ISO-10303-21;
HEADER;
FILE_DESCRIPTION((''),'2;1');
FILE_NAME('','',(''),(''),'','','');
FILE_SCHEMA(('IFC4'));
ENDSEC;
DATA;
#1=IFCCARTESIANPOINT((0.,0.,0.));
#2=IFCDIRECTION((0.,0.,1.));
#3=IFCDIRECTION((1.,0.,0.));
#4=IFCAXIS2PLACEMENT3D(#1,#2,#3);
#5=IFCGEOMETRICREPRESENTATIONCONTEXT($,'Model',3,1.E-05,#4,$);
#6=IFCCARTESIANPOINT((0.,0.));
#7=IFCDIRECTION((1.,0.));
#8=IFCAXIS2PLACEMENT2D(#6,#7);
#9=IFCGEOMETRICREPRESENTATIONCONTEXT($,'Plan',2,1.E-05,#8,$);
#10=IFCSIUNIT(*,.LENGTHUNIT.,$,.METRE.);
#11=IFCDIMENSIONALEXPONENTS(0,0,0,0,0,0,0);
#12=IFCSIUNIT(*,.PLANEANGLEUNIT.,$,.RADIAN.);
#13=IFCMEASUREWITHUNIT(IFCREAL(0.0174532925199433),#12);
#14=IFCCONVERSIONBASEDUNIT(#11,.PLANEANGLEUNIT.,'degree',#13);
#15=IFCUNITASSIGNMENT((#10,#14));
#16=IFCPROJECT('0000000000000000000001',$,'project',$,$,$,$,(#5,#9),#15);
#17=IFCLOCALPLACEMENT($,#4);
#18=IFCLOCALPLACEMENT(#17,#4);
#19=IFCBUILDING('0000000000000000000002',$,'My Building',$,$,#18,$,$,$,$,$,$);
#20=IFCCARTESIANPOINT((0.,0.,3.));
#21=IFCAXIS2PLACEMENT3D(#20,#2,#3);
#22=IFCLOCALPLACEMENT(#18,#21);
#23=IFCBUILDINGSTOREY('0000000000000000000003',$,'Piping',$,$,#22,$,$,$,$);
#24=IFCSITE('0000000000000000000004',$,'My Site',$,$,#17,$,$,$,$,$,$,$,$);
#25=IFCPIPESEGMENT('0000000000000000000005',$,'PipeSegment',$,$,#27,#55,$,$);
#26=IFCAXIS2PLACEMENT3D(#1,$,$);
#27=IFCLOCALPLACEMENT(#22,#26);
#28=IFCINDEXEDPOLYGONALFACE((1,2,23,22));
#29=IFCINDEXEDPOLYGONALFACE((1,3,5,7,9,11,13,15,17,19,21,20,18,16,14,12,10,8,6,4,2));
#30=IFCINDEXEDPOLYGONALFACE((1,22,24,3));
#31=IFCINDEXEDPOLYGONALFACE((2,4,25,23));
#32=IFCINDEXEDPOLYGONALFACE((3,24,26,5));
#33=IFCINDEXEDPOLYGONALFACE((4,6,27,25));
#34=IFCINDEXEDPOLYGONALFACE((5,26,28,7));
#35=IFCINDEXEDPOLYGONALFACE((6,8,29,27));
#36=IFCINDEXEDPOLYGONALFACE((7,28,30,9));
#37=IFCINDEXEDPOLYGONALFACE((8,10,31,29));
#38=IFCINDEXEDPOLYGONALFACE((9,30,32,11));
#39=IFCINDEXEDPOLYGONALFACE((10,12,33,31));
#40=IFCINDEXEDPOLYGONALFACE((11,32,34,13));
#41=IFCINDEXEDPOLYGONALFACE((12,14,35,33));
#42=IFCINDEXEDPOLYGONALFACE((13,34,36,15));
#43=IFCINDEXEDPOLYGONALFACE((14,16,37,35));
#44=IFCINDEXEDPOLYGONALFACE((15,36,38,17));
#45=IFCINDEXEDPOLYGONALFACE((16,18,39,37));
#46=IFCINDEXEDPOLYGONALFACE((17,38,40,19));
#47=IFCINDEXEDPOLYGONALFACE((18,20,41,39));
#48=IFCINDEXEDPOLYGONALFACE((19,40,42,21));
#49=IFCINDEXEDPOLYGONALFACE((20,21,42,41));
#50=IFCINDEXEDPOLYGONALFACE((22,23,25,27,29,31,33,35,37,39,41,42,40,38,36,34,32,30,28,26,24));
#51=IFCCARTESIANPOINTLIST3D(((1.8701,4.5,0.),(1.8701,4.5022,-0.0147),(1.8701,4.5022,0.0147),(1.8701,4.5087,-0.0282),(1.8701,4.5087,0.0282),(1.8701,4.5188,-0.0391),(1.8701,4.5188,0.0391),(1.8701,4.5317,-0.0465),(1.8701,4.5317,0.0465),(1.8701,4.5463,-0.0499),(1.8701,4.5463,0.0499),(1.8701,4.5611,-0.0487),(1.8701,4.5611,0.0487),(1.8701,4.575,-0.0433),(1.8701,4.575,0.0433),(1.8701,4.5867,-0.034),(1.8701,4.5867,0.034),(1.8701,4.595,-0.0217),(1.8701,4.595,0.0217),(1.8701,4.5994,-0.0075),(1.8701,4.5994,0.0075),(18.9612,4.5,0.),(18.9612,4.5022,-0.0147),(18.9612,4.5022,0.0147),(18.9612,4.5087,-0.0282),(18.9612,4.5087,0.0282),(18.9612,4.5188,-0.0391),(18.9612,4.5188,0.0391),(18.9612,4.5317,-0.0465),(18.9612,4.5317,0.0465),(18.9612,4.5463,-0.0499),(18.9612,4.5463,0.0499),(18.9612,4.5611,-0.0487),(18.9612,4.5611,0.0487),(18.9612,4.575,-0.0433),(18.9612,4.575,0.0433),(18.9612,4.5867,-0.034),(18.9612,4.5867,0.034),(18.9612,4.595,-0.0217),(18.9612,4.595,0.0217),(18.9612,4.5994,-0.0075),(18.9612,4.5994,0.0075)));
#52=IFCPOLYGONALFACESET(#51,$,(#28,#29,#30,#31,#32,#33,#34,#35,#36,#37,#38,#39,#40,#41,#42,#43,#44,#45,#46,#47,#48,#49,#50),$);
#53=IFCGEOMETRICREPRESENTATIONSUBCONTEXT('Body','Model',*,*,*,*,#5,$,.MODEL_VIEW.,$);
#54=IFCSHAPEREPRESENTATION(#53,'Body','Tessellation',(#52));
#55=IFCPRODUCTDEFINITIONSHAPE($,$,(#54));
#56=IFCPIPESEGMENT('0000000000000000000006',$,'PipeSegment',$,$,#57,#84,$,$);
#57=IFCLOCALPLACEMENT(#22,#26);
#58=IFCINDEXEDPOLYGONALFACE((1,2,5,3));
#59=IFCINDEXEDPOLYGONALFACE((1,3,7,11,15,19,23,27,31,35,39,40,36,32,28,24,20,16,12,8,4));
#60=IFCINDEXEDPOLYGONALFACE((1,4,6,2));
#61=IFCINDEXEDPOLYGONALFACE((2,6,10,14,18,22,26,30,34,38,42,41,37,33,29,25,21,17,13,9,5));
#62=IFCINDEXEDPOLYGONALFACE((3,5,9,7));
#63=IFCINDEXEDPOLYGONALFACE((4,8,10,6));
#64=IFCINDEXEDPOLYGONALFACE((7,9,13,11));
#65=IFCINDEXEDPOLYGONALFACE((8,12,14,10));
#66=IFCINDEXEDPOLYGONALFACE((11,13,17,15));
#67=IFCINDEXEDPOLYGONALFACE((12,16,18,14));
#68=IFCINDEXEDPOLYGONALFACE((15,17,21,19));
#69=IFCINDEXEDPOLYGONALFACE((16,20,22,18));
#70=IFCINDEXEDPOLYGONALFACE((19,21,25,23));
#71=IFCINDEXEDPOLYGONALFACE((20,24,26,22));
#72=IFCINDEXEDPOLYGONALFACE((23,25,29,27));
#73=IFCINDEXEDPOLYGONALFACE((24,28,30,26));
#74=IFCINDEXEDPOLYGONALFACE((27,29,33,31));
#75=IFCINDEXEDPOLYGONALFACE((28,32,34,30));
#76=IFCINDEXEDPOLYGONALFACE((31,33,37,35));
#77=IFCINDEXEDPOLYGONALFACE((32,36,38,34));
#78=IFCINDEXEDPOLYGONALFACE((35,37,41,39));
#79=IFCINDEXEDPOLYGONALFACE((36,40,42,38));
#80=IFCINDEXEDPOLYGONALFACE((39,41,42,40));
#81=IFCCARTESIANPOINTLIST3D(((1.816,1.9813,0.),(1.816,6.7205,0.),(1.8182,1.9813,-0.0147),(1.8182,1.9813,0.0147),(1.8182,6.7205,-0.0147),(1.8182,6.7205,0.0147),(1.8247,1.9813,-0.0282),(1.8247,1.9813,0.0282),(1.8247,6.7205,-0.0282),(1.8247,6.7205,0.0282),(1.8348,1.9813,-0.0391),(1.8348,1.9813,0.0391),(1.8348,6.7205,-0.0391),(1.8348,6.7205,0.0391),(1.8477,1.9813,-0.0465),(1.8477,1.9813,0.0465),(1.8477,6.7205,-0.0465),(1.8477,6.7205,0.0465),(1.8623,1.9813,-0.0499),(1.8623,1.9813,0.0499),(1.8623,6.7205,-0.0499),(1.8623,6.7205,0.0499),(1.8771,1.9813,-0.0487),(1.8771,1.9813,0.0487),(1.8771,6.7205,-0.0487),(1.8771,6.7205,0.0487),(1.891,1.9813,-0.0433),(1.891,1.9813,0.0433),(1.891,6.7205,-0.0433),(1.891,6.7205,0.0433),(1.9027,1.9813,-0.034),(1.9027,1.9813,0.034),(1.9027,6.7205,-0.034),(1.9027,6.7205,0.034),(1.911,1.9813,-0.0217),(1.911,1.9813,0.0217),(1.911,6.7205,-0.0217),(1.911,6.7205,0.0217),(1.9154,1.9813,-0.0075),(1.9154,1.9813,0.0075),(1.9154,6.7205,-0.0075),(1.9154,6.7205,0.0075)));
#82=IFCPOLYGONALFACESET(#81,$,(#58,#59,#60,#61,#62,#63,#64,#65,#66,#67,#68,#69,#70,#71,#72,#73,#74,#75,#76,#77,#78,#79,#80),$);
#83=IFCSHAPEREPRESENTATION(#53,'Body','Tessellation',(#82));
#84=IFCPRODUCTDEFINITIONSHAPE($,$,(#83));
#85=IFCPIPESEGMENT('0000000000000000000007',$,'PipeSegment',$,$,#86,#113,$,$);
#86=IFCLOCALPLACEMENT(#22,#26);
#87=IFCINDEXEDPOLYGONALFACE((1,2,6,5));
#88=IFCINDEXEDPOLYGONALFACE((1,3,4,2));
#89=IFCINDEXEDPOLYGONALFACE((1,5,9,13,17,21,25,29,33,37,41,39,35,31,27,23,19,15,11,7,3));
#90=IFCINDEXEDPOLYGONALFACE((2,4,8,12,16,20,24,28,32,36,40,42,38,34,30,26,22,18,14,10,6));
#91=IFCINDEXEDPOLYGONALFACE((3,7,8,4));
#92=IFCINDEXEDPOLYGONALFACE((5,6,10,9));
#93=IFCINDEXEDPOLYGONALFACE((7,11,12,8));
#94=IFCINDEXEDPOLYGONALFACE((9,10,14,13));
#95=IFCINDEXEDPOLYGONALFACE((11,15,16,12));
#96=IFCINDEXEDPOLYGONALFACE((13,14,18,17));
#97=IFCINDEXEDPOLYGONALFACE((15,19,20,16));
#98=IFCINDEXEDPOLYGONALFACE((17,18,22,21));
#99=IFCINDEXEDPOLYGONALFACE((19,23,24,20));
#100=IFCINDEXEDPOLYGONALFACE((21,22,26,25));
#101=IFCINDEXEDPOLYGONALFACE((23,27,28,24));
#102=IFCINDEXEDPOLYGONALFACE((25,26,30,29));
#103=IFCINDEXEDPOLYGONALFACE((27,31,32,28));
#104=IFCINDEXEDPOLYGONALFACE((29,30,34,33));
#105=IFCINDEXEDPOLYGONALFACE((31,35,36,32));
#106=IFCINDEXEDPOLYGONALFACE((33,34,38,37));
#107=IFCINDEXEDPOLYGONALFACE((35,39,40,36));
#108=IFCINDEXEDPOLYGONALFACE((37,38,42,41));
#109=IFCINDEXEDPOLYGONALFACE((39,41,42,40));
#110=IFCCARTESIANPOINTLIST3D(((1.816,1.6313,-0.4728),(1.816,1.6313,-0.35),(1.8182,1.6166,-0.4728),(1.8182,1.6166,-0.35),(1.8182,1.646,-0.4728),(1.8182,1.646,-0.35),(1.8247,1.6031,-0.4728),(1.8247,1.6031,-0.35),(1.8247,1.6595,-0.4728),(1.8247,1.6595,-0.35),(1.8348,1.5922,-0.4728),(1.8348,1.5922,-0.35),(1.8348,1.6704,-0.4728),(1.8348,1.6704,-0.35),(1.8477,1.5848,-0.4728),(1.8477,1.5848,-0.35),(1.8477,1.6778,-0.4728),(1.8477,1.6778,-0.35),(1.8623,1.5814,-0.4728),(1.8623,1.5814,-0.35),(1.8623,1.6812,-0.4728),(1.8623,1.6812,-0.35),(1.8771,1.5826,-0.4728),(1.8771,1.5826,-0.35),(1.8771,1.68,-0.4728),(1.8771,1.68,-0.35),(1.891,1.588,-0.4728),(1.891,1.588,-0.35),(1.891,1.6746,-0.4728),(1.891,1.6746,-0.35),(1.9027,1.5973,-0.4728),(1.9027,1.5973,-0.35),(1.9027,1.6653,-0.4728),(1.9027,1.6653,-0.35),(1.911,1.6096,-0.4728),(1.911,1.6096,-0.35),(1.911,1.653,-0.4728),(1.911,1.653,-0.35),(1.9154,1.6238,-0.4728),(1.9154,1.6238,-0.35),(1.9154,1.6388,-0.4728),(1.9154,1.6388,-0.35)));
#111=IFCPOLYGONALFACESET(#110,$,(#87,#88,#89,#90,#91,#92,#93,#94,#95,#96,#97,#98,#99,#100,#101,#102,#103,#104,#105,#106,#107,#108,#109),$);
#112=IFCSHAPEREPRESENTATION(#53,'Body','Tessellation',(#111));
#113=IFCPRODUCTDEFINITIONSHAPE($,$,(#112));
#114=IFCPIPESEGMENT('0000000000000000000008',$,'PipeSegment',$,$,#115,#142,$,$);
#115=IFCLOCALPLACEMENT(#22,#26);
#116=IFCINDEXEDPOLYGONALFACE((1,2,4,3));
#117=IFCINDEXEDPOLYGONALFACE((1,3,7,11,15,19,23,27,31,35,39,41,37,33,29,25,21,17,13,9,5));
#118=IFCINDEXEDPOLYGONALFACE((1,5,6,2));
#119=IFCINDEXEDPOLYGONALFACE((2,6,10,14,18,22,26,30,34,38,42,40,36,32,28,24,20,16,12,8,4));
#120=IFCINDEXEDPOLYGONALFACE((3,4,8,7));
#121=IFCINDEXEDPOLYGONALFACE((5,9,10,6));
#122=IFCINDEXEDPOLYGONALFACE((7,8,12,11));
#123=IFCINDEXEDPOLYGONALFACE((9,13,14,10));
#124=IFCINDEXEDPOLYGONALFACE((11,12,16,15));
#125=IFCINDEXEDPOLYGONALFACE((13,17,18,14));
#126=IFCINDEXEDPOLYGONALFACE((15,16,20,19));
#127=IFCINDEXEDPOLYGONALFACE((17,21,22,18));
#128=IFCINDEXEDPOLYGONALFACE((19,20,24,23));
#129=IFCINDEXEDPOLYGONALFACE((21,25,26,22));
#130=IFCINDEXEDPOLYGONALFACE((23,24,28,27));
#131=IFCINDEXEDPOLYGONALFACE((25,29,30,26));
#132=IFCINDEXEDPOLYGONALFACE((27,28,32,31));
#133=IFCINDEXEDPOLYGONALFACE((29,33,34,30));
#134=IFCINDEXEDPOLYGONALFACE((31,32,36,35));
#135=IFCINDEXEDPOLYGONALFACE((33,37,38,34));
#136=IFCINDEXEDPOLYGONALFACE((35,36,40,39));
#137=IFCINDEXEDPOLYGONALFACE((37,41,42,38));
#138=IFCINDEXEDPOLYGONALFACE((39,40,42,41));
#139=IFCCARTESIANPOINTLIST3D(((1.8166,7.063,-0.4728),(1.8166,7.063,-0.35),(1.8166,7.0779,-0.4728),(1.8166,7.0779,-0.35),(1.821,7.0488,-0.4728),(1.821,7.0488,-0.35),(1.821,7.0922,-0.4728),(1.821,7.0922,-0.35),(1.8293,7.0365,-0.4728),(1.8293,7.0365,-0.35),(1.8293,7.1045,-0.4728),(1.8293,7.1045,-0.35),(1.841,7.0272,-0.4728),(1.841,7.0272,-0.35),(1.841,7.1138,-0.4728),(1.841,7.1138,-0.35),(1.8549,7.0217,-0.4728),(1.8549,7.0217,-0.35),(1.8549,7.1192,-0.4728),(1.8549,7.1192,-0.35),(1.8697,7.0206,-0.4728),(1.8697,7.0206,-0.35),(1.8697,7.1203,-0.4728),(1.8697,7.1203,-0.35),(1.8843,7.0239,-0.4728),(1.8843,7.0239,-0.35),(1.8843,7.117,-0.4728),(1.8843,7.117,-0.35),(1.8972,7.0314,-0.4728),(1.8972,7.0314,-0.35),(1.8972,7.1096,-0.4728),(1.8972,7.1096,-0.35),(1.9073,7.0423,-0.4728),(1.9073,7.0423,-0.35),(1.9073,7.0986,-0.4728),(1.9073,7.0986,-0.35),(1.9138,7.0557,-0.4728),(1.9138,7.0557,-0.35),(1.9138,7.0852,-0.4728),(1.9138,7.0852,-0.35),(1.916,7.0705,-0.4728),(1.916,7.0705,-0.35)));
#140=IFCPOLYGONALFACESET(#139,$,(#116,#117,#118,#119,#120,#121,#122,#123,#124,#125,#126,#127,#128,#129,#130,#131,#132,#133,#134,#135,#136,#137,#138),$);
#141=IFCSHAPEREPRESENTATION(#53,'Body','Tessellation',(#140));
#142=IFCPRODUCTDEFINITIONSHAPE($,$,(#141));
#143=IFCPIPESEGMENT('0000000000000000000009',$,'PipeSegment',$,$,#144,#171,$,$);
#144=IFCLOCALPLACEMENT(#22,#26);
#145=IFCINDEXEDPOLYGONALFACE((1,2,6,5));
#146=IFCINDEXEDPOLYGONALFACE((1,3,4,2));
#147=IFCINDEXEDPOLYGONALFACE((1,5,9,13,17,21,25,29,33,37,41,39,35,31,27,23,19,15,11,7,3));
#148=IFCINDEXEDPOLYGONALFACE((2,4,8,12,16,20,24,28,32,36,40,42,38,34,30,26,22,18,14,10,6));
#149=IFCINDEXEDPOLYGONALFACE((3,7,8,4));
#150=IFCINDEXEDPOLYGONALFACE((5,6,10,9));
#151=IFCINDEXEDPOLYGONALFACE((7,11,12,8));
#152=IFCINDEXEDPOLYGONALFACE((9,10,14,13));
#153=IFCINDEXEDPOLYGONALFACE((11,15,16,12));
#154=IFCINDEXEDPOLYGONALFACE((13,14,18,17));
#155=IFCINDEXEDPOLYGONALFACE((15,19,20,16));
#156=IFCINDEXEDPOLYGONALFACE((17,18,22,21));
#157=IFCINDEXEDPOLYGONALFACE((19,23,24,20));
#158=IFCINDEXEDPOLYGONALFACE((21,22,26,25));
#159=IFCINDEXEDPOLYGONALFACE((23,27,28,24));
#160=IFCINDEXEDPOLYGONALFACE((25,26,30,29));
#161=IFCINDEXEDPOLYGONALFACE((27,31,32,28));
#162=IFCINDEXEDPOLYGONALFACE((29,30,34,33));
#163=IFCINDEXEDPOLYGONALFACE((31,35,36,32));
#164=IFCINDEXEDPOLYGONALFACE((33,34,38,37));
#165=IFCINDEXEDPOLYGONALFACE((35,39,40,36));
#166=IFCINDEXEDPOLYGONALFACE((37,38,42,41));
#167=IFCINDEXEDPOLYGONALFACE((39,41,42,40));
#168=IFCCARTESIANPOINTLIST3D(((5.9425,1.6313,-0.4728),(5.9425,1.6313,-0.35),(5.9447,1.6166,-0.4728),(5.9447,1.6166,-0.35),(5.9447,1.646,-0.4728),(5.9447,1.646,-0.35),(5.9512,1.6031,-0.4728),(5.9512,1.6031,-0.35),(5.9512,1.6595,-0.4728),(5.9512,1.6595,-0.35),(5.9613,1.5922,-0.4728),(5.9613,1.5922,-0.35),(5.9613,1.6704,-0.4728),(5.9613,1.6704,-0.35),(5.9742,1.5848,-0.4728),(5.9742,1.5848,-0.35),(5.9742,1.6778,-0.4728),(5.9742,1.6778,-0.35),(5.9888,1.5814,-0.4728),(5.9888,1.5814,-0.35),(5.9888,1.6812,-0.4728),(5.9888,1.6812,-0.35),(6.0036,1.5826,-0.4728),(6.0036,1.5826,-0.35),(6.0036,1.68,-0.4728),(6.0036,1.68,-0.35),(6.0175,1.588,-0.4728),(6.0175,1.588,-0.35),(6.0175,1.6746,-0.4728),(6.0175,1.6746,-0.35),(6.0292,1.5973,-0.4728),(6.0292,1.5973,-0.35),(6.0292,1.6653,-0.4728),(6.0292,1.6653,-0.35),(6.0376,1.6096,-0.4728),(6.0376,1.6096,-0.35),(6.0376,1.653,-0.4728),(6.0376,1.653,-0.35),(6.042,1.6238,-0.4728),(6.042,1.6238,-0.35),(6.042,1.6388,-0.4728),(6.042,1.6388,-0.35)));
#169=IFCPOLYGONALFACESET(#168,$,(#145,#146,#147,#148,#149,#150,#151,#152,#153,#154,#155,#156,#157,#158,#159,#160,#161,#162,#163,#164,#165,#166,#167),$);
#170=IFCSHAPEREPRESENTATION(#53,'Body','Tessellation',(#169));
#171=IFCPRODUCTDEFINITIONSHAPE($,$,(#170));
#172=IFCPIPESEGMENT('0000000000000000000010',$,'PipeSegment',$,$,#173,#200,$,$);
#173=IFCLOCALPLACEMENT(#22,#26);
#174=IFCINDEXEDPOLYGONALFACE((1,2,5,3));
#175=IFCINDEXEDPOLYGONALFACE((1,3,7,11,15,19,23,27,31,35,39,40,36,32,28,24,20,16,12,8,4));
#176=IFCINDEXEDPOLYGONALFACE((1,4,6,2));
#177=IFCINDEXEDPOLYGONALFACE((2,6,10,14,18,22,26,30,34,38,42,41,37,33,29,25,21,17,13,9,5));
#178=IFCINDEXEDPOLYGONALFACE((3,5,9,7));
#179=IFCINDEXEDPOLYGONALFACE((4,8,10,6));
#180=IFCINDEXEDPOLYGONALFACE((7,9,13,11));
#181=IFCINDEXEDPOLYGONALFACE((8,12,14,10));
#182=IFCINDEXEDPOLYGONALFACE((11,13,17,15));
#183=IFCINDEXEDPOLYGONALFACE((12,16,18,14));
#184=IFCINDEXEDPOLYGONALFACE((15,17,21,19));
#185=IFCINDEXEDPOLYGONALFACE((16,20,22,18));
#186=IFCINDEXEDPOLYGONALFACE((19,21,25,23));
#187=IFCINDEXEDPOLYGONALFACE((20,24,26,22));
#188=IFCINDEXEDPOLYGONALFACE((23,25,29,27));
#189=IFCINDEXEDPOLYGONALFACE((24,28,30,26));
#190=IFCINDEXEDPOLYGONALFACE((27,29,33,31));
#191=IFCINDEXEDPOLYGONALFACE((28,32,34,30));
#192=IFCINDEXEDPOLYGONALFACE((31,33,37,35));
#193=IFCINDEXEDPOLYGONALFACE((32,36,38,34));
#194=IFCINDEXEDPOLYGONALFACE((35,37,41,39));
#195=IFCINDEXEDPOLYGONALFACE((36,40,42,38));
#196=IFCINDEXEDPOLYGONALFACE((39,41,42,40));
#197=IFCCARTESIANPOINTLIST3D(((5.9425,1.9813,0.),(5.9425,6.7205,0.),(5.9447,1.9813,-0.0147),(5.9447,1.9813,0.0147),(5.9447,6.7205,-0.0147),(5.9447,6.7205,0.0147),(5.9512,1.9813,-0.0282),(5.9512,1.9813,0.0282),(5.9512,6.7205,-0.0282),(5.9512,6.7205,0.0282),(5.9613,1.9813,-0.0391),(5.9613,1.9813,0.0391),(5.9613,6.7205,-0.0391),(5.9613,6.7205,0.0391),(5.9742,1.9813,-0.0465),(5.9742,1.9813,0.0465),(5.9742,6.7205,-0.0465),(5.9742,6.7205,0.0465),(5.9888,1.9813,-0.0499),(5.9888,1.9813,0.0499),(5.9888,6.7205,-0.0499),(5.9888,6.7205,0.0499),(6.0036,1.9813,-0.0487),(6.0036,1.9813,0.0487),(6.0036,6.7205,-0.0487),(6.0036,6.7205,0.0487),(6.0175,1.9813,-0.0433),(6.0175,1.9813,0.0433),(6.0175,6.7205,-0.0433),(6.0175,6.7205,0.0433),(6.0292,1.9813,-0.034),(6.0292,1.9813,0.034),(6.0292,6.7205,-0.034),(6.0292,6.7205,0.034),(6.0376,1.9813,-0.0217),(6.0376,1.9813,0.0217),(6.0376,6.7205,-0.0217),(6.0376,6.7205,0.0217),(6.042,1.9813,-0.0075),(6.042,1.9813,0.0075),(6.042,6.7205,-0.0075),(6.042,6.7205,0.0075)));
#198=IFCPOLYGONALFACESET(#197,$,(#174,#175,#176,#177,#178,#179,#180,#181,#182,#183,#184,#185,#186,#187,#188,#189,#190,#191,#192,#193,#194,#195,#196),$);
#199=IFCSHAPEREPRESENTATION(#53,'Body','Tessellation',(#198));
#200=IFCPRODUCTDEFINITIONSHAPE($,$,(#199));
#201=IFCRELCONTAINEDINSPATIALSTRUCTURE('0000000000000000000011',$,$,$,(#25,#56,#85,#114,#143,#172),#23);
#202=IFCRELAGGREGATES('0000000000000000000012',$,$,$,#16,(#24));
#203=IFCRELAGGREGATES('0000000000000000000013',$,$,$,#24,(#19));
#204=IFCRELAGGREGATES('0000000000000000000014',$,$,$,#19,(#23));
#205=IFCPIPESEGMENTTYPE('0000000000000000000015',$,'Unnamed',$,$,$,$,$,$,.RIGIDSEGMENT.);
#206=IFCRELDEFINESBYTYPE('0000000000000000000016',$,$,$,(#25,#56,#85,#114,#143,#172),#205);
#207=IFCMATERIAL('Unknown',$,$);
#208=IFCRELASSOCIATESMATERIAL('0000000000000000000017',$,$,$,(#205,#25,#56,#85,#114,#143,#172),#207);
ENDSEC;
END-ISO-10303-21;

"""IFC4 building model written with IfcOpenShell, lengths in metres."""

from ifc_helpers import new_model, entity, si_unit, converted_unit, frame, origin_with_axes, origin_2d_with_axis, place, context, subcontext, project, spatial, circle, extrude, material, material_profile, profile_set, profile_usage, type_object, element, save


model = new_model("IFC4")

# Units and contexts
model_context = context("Model", 3, precision=1e-05, world=origin_with_axes())
plan_context = context("Plan", 2, precision=1e-05, world=origin_2d_with_axis())
body_context = subcontext(model_context, "Body", "Model", "MODEL_VIEW")
ifc_project = project(units=[si_unit("LENGTHUNIT", "METRE"), converted_unit("PLANEANGLEUNIT", "degree", entity("IfcReal", 0.0174532925199433), si_unit("PLANEANGLEUNIT", "RADIAN"), dimensions=[0, 0, 0, 0, 0, 0, 0])], contexts=[model_context, plan_context])

# Site, building, storey
site_placement = place(None, origin_with_axes())
site = spatial("IfcSite", under=ifc_project, at=site_placement, Name="My Site")
building_placement = place(site_placement, origin_with_axes())
building = spatial("IfcBuilding", under=site, at=building_placement, Name="My Building")
storey_placement = place(building_placement, frame((0.0, 0.0, 3.0), z_axis=(0.0, 0.0, 1.0), x_axis=(1.0, 0.0, 0.0)))
storey = spatial("IfcBuildingStorey", under=building, at=storey_placement, Name="Piping")

# Pipe segments
ifc_material = material(Name="Unknown")
ifc_material_profile = material_profile(ifc_material, circle(Radius=0.05))
ifc_profile_set = profile_set([ifc_material_profile])
ifc_profile_usage_1 = profile_usage(ifc_profile_set, cardinal=5)
pipe_segment_type = type_object("IfcPipeSegmentType", Name="Unnamed", PredefinedType="RIGIDSEGMENT", material=ifc_profile_set)
pipe_segment_1_placement = place(storey_placement, frame((18.9612, 4.55, 0.0), z_axis=(-1.0, 0.0, 0.0), x_axis=(0.0, -1.0, 0.0)))
element("IfcPipeSegment", 1, at=pipe_segment_1_placement, inside=storey, type_object=pipe_segment_type, material=ifc_profile_usage_1, Name="PipeSegment", context=body_context, shape_type="SweptSolid", body=[
    extrude(circle(Radius=0.05), origin_with_axes(), (0.0, 0.0, 1.0), 17.0911),
])
ifc_profile_usage_2 = profile_usage(ifc_profile_set, cardinal=5)
pipe_segment_2_placement = place(storey_placement, frame((1.866, 1.9813, 0.0), z_axis=(0.0, 1.0, 0.0), x_axis=(-1.0, 0.0, 0.0)))
element("IfcPipeSegment", 2, at=pipe_segment_2_placement, inside=storey, type_object=pipe_segment_type, material=ifc_profile_usage_2, Name="PipeSegment", context=body_context, shape_type="SweptSolid", body=[
    extrude(circle(Radius=0.05), origin_with_axes(), (0.0, 0.0, 1.0), 4.7392),
])
ifc_profile_usage_3 = profile_usage(ifc_profile_set, cardinal=5)
pipe_segment_3_placement = place(storey_placement, frame((1.866, 1.6313, -0.35), z_axis=(0.0, 0.0, -1.0), x_axis=(-1.0, 0.0, 0.0)))
element("IfcPipeSegment", 3, at=pipe_segment_3_placement, inside=storey, type_object=pipe_segment_type, material=ifc_profile_usage_3, Name="PipeSegment", context=body_context, shape_type="SweptSolid", body=[
    extrude(circle(Radius=0.05), origin_with_axes(), (0.0, 0.0, 1.0), 0.1228),
])
ifc_profile_usage_4 = profile_usage(ifc_profile_set, cardinal=5)
pipe_segment_4_placement = place(storey_placement, frame((1.866, 7.0705, -0.35), z_axis=(0.0, 0.0, -1.0), x_axis=(1.0, 0.0, 0.0)))
element("IfcPipeSegment", 4, at=pipe_segment_4_placement, inside=storey, type_object=pipe_segment_type, material=ifc_profile_usage_4, Name="PipeSegment", context=body_context, shape_type="SweptSolid", body=[
    extrude(circle(Radius=0.05), origin_with_axes(), (0.0, 0.0, 1.0), 0.1228),
])
ifc_profile_usage_5 = profile_usage(ifc_profile_set, cardinal=5)
pipe_segment_5_placement = place(storey_placement, frame((5.9925, 1.6313, -0.35), z_axis=(0.0, 0.0, -1.0), x_axis=(-1.0, 0.0, 0.0)))
element("IfcPipeSegment", 5, at=pipe_segment_5_placement, inside=storey, type_object=pipe_segment_type, material=ifc_profile_usage_5, Name="PipeSegment", context=body_context, shape_type="SweptSolid", body=[
    extrude(circle(Radius=0.05), origin_with_axes(), (0.0, 0.0, 1.0), 0.1228),
])
ifc_profile_usage_6 = profile_usage(ifc_profile_set, cardinal=5)
pipe_segment_6_placement = place(storey_placement, frame((5.9925, 1.9813, 0.0), z_axis=(0.0, 1.0, 0.0), x_axis=(-1.0, 0.0, 0.0)))
element("IfcPipeSegment", 6, at=pipe_segment_6_placement, inside=storey, type_object=pipe_segment_type, material=ifc_profile_usage_6, Name="PipeSegment", context=body_context, shape_type="SweptSolid", body=[
    extrude(circle(Radius=0.05), origin_with_axes(), (0.0, 0.0, 1.0), 4.7392),
])

save(model, "model.ifc")
